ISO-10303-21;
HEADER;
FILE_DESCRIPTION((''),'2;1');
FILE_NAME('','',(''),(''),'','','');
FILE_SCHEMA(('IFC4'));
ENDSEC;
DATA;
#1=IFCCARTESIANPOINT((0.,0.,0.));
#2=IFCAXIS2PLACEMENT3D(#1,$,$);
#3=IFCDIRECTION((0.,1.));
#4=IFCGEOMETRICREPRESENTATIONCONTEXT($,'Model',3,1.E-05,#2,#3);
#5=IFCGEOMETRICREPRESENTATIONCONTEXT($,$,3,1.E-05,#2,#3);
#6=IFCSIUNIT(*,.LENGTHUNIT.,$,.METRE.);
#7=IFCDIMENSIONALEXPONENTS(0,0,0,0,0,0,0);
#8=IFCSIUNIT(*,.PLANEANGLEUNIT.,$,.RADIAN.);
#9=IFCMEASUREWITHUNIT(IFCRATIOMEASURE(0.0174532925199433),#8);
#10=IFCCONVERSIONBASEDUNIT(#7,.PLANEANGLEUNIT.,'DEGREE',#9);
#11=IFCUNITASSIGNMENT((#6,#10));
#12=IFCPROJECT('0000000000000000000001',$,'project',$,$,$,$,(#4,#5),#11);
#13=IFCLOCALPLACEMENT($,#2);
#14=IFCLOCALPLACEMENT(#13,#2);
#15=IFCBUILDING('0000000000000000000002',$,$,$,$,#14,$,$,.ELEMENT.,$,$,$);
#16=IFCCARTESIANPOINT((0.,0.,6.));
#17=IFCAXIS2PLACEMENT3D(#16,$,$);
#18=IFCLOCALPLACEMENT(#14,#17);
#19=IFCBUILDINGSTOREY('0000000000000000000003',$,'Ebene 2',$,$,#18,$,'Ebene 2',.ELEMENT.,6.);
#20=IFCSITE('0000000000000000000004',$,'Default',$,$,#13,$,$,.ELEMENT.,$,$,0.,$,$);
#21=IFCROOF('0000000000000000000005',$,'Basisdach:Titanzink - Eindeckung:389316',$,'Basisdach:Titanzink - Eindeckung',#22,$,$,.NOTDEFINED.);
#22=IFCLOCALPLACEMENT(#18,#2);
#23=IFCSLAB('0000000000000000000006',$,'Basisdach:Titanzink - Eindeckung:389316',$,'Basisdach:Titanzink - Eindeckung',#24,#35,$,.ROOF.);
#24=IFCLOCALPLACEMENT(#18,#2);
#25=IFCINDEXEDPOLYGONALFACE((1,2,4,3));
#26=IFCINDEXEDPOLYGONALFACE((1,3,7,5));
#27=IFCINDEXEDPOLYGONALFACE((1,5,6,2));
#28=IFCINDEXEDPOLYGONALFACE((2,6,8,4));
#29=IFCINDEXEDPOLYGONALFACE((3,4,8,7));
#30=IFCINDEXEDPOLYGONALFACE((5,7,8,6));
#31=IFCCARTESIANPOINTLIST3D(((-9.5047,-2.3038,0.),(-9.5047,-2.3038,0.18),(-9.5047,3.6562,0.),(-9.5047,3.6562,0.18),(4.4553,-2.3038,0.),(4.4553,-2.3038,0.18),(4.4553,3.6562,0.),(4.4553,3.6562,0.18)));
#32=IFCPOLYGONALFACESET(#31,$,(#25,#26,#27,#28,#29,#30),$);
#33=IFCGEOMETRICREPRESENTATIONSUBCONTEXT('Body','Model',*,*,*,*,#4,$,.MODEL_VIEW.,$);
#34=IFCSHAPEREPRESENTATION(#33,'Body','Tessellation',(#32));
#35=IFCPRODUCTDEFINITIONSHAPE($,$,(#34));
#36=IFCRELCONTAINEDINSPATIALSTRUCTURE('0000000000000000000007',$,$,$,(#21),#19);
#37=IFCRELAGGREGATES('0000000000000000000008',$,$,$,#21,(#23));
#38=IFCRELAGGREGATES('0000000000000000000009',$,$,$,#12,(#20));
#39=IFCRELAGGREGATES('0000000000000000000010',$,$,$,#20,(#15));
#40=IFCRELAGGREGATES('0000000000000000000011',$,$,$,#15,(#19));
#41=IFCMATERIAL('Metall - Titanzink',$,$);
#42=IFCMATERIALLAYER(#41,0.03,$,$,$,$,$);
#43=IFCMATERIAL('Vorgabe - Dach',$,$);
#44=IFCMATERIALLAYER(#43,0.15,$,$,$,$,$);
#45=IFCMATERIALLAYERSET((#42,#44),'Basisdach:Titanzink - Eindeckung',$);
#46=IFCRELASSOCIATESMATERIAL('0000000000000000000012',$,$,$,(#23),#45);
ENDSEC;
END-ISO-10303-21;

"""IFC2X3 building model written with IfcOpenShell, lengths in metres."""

from ifc_helpers import new_model, entity, si_unit, converted_unit, direction, frame, frame_2d, origin, place, context, subcontext, project, spatial, rectangle, extrude, material, layer, layer_set, element, aggregate, save


model = new_model("IFC2X3")

# Units and contexts
model_context = context("Model", 3, precision=1e-05, world=origin(), true_north=direction((0.0, 1.0)))
context_of_model = context(None, 3, precision=1e-05, world=origin(), true_north=direction((0.0, 1.0)))
body_context = subcontext(model_context, "Body", "Model", "MODEL_VIEW")
ifc_project = project(units=[si_unit("LENGTHUNIT", "METRE"), converted_unit("PLANEANGLEUNIT", "DEGREE", entity("IfcRatioMeasure", 0.0174532925199433), si_unit("PLANEANGLEUNIT", "RADIAN"), dimensions=[0, 0, 0, 0, 0, 0, 0])], contexts=[model_context, context_of_model])

# Site, building, storey
site_placement = place(None, origin())
site = spatial("IfcSite", under=ifc_project, at=site_placement, Name="Default", CompositionType="ELEMENT", RefElevation=0.0)
building_placement = place(site_placement, origin())
building = spatial("IfcBuilding", under=site, at=building_placement, CompositionType="ELEMENT")
storey_placement = place(building_placement, frame((0.0, 0.0, 6.0)))
storey = spatial("IfcBuildingStorey", under=building, at=storey_placement, Name="Ebene 2", LongName="Ebene 2", CompositionType="ELEMENT", Elevation=6.0)

# Roof, slab
roof_placement = place(storey_placement, frame((-9.5047, -2.3038, 0.0)))
roof = element("IfcRoof", 1, at=roof_placement, inside=storey, Name="Basisdach:Titanzink - Eindeckung:389316", ObjectType="Basisdach:Titanzink - Eindeckung", ShapeType="NOTDEFINED")
ifc_material_1 = material(Name="Metall - Titanzink")
ifc_layer_1 = layer(ifc_material_1, 0.03)
ifc_material_2 = material(Name="Vorgabe - Dach")
ifc_layer_2 = layer(ifc_material_2, 0.15)
ifc_layer_set = layer_set([ifc_layer_1, ifc_layer_2], Name="Basisdach:Titanzink - Eindeckung")
slab_placement = place(roof_placement, origin())
slab = element("IfcSlab", 2, at=slab_placement, material=ifc_layer_set, Name="Basisdach:Titanzink - Eindeckung:389316", ObjectType="Basisdach:Titanzink - Eindeckung", PredefinedType="ROOF", context=body_context, shape_type="SweptSolid", body=[
    extrude(rectangle(XDim=13.96, YDim=5.96, at=frame_2d((0.0, 0.0), x_axis=(1.0, 0.0))), frame((6.98, 2.98, 0.0)), (0.0, 0.0, 1.0), 0.18),
])
aggregate(roof, [slab])

save(model, "model.ifc")
